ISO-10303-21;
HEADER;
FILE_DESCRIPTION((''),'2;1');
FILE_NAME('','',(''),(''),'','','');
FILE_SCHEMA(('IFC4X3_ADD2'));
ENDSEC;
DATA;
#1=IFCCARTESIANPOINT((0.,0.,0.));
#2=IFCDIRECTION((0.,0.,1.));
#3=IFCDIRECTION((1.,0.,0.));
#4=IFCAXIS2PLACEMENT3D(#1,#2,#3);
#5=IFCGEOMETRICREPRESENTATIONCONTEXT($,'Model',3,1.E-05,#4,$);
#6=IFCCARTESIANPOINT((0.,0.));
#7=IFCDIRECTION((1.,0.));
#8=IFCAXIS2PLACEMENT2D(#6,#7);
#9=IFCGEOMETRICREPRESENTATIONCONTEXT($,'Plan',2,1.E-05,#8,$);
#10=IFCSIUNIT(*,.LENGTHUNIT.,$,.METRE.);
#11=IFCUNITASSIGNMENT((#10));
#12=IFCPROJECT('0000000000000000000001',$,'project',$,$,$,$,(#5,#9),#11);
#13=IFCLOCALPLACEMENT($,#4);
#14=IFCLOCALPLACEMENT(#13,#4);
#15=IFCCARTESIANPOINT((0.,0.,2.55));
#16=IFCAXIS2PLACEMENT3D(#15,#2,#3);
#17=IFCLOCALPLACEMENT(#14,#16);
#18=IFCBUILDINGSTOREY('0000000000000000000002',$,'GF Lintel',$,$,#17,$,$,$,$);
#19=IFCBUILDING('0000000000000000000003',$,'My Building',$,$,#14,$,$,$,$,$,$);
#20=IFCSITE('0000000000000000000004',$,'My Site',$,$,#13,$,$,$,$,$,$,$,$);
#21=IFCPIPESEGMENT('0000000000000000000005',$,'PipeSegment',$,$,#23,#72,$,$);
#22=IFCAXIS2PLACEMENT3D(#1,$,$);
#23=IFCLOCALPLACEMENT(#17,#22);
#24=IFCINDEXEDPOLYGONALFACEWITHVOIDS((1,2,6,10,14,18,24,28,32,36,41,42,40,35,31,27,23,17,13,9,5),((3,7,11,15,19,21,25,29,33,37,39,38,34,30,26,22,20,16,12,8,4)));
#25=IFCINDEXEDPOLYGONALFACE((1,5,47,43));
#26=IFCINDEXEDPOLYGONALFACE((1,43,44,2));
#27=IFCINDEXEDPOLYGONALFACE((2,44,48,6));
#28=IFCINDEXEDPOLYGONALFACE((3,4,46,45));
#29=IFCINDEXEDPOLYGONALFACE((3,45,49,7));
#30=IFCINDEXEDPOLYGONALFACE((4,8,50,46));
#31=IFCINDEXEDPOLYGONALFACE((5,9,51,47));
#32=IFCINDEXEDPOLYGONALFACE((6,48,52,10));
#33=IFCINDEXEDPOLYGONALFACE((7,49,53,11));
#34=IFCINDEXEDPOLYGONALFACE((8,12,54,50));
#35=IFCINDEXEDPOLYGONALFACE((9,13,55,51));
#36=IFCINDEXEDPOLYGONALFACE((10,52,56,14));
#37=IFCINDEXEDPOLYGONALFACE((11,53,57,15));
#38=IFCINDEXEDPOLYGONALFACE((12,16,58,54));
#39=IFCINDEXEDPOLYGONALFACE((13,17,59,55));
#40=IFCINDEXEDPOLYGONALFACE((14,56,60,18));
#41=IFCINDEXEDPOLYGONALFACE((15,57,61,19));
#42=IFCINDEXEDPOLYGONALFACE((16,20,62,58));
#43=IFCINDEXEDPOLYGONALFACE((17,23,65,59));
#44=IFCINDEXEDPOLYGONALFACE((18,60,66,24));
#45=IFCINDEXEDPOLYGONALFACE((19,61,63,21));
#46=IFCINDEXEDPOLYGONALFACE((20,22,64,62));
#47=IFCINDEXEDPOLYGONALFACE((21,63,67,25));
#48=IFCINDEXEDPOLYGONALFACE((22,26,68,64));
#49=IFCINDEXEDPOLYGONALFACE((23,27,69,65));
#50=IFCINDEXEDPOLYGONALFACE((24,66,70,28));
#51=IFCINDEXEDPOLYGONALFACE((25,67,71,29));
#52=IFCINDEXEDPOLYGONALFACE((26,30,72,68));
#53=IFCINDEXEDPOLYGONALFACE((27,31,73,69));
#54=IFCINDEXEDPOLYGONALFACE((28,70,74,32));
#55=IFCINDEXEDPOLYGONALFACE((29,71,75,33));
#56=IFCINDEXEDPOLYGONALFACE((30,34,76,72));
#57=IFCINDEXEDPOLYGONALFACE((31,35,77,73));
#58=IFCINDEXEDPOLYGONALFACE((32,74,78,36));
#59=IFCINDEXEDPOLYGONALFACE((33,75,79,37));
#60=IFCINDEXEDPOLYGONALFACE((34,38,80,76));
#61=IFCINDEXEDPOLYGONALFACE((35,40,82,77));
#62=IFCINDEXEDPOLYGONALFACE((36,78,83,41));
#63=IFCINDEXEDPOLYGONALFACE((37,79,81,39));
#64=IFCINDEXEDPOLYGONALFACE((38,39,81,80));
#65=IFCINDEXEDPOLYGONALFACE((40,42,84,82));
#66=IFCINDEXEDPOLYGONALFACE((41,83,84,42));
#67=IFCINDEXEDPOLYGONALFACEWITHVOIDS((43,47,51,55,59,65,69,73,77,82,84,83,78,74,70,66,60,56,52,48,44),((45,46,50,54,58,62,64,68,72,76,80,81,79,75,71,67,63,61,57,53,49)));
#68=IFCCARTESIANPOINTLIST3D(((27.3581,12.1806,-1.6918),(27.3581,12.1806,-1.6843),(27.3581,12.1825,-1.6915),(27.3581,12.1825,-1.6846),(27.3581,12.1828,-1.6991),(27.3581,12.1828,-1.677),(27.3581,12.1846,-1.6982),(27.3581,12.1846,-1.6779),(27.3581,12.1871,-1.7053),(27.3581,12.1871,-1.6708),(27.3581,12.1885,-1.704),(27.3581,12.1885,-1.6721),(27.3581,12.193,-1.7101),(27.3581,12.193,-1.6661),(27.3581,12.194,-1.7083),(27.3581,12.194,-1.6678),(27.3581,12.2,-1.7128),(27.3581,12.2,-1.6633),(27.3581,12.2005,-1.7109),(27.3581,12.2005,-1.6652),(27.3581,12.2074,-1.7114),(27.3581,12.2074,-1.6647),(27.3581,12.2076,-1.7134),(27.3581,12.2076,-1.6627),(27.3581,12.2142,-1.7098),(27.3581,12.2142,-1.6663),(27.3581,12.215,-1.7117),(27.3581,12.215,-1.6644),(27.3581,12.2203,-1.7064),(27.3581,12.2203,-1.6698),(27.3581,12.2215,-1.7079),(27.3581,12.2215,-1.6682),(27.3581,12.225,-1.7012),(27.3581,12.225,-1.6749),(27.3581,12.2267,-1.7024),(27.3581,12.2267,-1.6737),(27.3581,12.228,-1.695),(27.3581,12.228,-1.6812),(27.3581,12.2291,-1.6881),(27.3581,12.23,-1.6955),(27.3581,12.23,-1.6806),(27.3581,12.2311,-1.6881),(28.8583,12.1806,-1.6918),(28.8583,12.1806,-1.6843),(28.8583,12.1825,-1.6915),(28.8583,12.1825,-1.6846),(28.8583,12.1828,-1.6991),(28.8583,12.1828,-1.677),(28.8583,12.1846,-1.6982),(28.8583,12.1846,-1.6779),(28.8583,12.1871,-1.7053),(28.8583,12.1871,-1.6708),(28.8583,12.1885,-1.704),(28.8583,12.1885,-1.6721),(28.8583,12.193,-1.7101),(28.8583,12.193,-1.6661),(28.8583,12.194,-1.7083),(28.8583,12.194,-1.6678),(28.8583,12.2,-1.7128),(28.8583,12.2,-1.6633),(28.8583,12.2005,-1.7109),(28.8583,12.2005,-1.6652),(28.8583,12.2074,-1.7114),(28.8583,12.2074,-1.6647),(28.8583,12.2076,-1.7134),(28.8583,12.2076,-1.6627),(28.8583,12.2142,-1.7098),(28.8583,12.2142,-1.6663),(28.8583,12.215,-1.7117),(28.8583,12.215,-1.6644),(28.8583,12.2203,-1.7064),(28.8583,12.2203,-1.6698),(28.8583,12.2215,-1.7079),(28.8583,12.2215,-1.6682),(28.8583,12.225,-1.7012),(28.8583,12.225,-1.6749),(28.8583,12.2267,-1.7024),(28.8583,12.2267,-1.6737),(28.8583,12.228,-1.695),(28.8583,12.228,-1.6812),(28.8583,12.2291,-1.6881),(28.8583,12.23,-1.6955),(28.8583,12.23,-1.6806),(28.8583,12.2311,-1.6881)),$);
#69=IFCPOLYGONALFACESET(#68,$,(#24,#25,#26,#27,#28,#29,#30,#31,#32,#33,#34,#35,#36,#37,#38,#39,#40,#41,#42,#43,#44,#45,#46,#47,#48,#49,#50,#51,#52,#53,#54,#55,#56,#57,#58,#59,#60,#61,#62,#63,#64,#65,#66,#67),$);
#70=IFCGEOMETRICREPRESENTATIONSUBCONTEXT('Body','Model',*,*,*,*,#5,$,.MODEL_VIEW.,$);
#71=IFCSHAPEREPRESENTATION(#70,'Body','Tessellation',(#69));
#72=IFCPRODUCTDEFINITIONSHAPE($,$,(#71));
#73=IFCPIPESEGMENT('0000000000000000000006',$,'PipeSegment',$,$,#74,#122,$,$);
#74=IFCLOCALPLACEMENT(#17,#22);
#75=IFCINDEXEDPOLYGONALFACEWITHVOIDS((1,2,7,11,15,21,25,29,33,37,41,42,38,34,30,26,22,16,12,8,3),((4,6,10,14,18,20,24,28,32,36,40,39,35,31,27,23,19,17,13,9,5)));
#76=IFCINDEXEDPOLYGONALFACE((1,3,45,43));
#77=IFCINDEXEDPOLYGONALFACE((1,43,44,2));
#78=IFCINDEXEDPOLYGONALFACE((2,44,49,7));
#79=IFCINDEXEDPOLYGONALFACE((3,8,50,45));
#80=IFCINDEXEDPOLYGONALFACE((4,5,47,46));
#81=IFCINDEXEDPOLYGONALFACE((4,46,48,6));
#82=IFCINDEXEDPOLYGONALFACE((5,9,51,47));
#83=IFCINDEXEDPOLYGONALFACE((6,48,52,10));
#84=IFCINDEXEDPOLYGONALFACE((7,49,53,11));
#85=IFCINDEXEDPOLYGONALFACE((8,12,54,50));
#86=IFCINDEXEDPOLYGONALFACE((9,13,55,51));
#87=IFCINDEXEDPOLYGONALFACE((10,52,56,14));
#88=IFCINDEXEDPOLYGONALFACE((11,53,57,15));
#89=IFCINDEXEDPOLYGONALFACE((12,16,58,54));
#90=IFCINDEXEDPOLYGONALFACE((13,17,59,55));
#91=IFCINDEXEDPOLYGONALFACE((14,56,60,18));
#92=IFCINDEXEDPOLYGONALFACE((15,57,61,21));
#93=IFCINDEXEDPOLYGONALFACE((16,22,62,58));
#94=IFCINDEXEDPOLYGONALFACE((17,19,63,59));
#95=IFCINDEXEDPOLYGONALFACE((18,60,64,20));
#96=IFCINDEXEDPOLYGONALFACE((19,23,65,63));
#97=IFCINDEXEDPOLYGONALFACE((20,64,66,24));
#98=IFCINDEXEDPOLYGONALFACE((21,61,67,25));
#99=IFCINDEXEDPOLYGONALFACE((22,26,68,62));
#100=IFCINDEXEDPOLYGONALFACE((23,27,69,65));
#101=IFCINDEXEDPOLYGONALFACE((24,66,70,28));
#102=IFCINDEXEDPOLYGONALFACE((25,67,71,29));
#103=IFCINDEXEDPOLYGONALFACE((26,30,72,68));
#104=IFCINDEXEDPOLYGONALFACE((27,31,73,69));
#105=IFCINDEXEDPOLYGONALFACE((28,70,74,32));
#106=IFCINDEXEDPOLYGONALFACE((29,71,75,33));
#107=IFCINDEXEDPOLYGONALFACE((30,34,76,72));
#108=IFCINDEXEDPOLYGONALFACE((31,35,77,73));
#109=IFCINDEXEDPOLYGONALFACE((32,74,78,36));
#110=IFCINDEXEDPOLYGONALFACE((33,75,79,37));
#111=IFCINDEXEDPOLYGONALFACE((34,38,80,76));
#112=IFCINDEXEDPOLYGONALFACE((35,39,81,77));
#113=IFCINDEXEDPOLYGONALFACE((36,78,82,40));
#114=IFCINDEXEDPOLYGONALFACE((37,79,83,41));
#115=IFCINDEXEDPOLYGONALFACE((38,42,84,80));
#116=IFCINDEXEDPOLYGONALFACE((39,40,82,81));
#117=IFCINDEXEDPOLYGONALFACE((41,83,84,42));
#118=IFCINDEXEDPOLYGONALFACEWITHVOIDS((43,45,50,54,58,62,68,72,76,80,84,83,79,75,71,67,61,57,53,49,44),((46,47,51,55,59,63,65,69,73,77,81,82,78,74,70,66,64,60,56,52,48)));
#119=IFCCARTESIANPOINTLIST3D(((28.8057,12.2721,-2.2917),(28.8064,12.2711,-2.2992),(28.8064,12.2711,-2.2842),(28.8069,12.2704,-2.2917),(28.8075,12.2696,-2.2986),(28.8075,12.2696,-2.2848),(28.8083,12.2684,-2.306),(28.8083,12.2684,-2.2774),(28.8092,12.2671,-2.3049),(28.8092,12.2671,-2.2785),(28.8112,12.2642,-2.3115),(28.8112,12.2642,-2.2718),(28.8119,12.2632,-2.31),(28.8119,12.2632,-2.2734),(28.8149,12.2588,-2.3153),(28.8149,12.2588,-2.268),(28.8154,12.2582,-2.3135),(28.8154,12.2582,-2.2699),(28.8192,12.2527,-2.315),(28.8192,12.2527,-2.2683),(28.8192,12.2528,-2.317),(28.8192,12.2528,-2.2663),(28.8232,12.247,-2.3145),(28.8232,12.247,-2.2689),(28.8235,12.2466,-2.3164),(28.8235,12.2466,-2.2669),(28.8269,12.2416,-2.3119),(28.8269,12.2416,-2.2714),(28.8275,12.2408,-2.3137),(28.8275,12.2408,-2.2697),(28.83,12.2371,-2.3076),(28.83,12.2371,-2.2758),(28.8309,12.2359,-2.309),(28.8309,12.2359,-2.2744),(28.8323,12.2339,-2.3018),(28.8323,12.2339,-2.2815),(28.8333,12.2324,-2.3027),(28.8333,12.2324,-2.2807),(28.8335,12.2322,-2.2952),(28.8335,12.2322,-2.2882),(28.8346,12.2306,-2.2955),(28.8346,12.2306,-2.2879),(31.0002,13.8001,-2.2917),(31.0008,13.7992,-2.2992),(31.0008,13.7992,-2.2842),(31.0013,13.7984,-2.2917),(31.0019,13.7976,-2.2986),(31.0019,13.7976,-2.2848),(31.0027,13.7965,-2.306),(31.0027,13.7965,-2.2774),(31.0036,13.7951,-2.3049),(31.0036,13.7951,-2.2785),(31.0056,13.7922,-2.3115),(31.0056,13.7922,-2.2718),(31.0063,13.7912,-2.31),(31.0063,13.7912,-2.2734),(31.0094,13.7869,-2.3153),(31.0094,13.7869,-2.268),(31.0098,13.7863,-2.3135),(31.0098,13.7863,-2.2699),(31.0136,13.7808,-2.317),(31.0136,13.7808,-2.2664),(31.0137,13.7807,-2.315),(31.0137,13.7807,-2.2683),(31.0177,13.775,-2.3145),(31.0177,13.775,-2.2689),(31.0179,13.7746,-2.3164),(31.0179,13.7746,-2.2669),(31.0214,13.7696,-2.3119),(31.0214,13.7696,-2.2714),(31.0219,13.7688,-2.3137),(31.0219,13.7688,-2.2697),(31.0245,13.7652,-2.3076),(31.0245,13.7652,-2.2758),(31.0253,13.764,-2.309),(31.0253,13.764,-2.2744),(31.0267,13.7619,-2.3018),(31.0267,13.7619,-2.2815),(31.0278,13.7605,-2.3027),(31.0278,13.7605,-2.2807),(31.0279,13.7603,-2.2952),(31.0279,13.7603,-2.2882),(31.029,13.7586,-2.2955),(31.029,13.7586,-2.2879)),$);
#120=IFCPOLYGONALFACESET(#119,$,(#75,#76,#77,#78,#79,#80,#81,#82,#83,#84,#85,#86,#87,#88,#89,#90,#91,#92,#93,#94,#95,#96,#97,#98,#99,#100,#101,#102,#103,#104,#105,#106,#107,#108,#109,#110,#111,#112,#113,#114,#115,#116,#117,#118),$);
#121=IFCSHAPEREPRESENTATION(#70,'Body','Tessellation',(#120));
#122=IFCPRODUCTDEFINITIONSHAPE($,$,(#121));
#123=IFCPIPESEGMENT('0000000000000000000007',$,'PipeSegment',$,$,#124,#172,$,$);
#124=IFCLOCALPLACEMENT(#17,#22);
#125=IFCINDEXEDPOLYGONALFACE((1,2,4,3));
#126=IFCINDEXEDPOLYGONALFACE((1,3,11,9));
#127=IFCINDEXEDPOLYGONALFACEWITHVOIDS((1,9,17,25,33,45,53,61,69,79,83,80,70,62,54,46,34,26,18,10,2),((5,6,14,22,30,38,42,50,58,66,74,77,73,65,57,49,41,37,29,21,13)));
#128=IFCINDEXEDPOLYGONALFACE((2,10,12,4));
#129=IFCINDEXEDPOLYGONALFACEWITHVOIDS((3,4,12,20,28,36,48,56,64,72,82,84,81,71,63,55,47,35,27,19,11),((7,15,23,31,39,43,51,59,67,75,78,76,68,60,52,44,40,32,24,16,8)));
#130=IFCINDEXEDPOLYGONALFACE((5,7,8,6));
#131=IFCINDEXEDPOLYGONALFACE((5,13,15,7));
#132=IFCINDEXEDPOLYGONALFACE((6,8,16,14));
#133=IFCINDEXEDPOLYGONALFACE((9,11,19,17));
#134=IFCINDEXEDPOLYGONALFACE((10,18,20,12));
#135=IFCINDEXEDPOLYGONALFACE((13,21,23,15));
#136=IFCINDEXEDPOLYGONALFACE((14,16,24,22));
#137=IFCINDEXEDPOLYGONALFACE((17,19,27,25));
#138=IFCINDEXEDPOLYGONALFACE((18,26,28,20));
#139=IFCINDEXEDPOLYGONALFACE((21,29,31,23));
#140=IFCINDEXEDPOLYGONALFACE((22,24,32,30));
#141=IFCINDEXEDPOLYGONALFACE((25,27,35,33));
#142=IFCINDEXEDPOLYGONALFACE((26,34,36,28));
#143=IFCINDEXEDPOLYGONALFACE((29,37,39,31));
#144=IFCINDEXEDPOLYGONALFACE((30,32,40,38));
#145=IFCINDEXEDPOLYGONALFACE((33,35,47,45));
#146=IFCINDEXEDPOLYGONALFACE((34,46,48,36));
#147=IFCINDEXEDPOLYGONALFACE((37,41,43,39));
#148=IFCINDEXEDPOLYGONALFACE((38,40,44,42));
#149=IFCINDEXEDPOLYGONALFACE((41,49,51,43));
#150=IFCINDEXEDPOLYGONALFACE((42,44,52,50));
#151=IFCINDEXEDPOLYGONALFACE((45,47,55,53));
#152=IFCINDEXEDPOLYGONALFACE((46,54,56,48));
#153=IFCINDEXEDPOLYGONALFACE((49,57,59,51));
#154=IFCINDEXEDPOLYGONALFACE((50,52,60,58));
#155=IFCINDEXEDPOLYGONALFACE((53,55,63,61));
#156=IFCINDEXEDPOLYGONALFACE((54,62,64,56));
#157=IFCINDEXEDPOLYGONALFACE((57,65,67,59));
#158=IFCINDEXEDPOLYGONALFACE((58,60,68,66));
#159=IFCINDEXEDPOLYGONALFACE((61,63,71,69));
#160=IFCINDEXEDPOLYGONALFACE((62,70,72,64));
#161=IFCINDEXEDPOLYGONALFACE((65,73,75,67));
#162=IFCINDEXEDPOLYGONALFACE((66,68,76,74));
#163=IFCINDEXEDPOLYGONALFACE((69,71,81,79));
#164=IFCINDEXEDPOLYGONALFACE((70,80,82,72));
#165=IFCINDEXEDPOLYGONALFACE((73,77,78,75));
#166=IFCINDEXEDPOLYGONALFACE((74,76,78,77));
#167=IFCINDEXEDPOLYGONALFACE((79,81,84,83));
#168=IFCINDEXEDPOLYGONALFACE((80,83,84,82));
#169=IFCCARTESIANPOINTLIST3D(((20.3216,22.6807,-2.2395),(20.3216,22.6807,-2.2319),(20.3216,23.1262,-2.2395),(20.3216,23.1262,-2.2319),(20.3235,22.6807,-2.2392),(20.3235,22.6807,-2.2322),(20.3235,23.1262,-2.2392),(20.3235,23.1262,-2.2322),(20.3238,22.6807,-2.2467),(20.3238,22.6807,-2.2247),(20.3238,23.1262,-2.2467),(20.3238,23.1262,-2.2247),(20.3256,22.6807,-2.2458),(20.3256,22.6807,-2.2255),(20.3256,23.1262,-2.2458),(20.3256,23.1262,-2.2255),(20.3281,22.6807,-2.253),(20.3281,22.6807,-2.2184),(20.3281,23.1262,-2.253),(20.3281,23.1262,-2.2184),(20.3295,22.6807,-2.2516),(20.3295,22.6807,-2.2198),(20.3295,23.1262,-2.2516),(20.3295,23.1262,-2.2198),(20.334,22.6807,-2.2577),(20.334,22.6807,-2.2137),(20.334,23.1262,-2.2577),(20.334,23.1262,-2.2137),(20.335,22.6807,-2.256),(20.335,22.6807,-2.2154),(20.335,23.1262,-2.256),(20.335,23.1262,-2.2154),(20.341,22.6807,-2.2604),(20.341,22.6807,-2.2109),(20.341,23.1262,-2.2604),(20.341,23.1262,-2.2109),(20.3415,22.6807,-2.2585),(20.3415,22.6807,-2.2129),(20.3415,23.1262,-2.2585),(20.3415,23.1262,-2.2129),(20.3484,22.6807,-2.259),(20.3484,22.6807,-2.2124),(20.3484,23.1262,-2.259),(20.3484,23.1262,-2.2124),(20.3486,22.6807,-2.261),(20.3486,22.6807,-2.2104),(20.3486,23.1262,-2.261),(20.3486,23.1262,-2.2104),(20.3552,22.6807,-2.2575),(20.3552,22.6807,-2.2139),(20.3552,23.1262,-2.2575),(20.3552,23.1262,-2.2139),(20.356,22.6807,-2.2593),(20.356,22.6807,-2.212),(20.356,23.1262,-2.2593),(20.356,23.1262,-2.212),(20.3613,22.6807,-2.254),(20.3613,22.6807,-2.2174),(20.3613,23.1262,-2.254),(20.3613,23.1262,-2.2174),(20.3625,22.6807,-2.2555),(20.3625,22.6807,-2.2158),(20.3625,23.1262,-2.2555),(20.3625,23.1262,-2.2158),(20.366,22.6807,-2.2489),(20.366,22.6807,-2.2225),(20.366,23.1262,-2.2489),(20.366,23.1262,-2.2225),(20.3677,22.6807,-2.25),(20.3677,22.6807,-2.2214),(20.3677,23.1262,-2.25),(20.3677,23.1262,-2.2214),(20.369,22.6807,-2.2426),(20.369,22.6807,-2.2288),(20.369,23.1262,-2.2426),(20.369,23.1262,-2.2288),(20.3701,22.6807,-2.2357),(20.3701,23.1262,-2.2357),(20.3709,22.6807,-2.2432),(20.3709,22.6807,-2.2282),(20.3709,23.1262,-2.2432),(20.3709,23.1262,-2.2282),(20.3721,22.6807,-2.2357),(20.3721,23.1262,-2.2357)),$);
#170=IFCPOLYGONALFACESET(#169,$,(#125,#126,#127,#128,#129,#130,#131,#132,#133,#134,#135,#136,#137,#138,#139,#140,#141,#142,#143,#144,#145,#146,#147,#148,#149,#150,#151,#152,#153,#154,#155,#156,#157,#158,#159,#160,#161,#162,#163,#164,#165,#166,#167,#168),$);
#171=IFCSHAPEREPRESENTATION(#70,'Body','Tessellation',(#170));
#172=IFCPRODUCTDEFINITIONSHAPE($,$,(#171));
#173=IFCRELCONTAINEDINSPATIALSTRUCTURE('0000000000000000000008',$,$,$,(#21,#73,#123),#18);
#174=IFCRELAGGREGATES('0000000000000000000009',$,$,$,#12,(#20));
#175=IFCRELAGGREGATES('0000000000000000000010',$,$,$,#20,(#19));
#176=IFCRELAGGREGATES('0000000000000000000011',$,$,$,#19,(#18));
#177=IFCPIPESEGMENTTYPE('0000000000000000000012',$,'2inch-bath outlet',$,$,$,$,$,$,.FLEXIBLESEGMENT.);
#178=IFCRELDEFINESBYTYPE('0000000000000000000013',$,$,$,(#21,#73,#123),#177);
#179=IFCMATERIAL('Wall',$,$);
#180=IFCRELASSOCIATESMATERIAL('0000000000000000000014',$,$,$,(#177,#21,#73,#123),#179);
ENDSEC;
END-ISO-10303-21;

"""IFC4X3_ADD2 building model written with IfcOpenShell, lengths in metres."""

from ifc_helpers import new_model, si_unit, frame, origin_with_axes, origin_2d_with_axis, place, context, subcontext, project, spatial, hollow_circle, extrude, material, material_profile, profile_set, profile_usage, type_object, element, save


model = new_model("IFC4X3_ADD2")

# Units and contexts
model_context = context("Model", 3, precision=1e-05, world=origin_with_axes())
plan_context = context("Plan", 2, precision=1e-05, world=origin_2d_with_axis())
body_context = subcontext(model_context, "Body", "Model", "MODEL_VIEW")
ifc_project = project(units=[si_unit("LENGTHUNIT", "METRE")], contexts=[model_context, plan_context])

# Site, building, storey
site_placement = place(None, origin_with_axes())
site = spatial("IfcSite", under=ifc_project, at=site_placement, Name="My Site")
building_placement = place(site_placement, origin_with_axes())
building = spatial("IfcBuilding", under=site, at=building_placement, Name="My Building")
storey_placement = place(building_placement, frame((0.0, 0.0, 2.55), z_axis=(0.0, 0.0, 1.0), x_axis=(1.0, 0.0, 0.0)))
storey = spatial("IfcBuildingStorey", under=building, at=storey_placement, Name="GF Lintel")

# Shared definitions
ifc_material_1 = material(Name="Wall")

# Pipe segments
ifc_material_profile_1 = material_profile(ifc_material_1, hollow_circle(Radius=0.0254, WallThickness=0.002))
ifc_profile_set_1 = profile_set([ifc_material_profile_1], Name="graywater")
pipe_segment_type_1 = type_object("IfcPipeSegmentType", Name="2inch-bath outlet", PredefinedType="FLEXIBLESEGMENT", material=ifc_profile_set_1)
ifc_profile_usage_1 = profile_usage(ifc_profile_set_1, cardinal=5)
pipe_segment_1_placement = place(storey_placement, frame((27.3581, 12.2057, -1.6881), z_axis=(1.0, 0.0, 0.0), x_axis=(0.0, 1.0, 0.0)))
element("IfcPipeSegment", 1, at=pipe_segment_1_placement, inside=storey, type_object=pipe_segment_type_1, material=ifc_profile_usage_1, Name="PipeSegment", context=body_context, shape_type="SweptSolid", body=[
    extrude(hollow_circle(Radius=0.0254, WallThickness=0.002), origin_with_axes(), (0.0, 0.0, 1.0), 1.5002),
])
ifc_profile_usage_2 = profile_usage(ifc_profile_set_1, cardinal=5)
pipe_segment_2_placement = place(storey_placement, frame((28.8202, 12.2512, -2.2917), z_axis=(0.820651, 0.57143, 0.0), x_axis=(-0.57143, 0.820651, 0.0)))
element("IfcPipeSegment", 2, at=pipe_segment_2_placement, inside=storey, type_object=pipe_segment_type_1, material=ifc_profile_usage_2, Name="PipeSegment", context=body_context, shape_type="SweptSolid", body=[
    extrude(hollow_circle(Radius=0.0254, WallThickness=0.002), origin_with_axes(), (0.0, 0.0, 1.0), 2.674),
])
ifc_profile_usage_3 = profile_usage(ifc_profile_set_1, cardinal=5)
pipe_segment_3_placement = place(storey_placement, frame((20.3467, 23.1262, -2.2357), z_axis=(0.0, -1.0, 0.0), x_axis=(1.0, 0.0, 0.0)))
element("IfcPipeSegment", 3, at=pipe_segment_3_placement, inside=storey, type_object=pipe_segment_type_1, material=ifc_profile_usage_3, Name="PipeSegment", context=body_context, shape_type="SweptSolid", body=[
    extrude(hollow_circle(Radius=0.0254, WallThickness=0.002), origin_with_axes(), (0.0, 0.0, 1.0), 0.4455),
])

save(model, "model.ifc")
